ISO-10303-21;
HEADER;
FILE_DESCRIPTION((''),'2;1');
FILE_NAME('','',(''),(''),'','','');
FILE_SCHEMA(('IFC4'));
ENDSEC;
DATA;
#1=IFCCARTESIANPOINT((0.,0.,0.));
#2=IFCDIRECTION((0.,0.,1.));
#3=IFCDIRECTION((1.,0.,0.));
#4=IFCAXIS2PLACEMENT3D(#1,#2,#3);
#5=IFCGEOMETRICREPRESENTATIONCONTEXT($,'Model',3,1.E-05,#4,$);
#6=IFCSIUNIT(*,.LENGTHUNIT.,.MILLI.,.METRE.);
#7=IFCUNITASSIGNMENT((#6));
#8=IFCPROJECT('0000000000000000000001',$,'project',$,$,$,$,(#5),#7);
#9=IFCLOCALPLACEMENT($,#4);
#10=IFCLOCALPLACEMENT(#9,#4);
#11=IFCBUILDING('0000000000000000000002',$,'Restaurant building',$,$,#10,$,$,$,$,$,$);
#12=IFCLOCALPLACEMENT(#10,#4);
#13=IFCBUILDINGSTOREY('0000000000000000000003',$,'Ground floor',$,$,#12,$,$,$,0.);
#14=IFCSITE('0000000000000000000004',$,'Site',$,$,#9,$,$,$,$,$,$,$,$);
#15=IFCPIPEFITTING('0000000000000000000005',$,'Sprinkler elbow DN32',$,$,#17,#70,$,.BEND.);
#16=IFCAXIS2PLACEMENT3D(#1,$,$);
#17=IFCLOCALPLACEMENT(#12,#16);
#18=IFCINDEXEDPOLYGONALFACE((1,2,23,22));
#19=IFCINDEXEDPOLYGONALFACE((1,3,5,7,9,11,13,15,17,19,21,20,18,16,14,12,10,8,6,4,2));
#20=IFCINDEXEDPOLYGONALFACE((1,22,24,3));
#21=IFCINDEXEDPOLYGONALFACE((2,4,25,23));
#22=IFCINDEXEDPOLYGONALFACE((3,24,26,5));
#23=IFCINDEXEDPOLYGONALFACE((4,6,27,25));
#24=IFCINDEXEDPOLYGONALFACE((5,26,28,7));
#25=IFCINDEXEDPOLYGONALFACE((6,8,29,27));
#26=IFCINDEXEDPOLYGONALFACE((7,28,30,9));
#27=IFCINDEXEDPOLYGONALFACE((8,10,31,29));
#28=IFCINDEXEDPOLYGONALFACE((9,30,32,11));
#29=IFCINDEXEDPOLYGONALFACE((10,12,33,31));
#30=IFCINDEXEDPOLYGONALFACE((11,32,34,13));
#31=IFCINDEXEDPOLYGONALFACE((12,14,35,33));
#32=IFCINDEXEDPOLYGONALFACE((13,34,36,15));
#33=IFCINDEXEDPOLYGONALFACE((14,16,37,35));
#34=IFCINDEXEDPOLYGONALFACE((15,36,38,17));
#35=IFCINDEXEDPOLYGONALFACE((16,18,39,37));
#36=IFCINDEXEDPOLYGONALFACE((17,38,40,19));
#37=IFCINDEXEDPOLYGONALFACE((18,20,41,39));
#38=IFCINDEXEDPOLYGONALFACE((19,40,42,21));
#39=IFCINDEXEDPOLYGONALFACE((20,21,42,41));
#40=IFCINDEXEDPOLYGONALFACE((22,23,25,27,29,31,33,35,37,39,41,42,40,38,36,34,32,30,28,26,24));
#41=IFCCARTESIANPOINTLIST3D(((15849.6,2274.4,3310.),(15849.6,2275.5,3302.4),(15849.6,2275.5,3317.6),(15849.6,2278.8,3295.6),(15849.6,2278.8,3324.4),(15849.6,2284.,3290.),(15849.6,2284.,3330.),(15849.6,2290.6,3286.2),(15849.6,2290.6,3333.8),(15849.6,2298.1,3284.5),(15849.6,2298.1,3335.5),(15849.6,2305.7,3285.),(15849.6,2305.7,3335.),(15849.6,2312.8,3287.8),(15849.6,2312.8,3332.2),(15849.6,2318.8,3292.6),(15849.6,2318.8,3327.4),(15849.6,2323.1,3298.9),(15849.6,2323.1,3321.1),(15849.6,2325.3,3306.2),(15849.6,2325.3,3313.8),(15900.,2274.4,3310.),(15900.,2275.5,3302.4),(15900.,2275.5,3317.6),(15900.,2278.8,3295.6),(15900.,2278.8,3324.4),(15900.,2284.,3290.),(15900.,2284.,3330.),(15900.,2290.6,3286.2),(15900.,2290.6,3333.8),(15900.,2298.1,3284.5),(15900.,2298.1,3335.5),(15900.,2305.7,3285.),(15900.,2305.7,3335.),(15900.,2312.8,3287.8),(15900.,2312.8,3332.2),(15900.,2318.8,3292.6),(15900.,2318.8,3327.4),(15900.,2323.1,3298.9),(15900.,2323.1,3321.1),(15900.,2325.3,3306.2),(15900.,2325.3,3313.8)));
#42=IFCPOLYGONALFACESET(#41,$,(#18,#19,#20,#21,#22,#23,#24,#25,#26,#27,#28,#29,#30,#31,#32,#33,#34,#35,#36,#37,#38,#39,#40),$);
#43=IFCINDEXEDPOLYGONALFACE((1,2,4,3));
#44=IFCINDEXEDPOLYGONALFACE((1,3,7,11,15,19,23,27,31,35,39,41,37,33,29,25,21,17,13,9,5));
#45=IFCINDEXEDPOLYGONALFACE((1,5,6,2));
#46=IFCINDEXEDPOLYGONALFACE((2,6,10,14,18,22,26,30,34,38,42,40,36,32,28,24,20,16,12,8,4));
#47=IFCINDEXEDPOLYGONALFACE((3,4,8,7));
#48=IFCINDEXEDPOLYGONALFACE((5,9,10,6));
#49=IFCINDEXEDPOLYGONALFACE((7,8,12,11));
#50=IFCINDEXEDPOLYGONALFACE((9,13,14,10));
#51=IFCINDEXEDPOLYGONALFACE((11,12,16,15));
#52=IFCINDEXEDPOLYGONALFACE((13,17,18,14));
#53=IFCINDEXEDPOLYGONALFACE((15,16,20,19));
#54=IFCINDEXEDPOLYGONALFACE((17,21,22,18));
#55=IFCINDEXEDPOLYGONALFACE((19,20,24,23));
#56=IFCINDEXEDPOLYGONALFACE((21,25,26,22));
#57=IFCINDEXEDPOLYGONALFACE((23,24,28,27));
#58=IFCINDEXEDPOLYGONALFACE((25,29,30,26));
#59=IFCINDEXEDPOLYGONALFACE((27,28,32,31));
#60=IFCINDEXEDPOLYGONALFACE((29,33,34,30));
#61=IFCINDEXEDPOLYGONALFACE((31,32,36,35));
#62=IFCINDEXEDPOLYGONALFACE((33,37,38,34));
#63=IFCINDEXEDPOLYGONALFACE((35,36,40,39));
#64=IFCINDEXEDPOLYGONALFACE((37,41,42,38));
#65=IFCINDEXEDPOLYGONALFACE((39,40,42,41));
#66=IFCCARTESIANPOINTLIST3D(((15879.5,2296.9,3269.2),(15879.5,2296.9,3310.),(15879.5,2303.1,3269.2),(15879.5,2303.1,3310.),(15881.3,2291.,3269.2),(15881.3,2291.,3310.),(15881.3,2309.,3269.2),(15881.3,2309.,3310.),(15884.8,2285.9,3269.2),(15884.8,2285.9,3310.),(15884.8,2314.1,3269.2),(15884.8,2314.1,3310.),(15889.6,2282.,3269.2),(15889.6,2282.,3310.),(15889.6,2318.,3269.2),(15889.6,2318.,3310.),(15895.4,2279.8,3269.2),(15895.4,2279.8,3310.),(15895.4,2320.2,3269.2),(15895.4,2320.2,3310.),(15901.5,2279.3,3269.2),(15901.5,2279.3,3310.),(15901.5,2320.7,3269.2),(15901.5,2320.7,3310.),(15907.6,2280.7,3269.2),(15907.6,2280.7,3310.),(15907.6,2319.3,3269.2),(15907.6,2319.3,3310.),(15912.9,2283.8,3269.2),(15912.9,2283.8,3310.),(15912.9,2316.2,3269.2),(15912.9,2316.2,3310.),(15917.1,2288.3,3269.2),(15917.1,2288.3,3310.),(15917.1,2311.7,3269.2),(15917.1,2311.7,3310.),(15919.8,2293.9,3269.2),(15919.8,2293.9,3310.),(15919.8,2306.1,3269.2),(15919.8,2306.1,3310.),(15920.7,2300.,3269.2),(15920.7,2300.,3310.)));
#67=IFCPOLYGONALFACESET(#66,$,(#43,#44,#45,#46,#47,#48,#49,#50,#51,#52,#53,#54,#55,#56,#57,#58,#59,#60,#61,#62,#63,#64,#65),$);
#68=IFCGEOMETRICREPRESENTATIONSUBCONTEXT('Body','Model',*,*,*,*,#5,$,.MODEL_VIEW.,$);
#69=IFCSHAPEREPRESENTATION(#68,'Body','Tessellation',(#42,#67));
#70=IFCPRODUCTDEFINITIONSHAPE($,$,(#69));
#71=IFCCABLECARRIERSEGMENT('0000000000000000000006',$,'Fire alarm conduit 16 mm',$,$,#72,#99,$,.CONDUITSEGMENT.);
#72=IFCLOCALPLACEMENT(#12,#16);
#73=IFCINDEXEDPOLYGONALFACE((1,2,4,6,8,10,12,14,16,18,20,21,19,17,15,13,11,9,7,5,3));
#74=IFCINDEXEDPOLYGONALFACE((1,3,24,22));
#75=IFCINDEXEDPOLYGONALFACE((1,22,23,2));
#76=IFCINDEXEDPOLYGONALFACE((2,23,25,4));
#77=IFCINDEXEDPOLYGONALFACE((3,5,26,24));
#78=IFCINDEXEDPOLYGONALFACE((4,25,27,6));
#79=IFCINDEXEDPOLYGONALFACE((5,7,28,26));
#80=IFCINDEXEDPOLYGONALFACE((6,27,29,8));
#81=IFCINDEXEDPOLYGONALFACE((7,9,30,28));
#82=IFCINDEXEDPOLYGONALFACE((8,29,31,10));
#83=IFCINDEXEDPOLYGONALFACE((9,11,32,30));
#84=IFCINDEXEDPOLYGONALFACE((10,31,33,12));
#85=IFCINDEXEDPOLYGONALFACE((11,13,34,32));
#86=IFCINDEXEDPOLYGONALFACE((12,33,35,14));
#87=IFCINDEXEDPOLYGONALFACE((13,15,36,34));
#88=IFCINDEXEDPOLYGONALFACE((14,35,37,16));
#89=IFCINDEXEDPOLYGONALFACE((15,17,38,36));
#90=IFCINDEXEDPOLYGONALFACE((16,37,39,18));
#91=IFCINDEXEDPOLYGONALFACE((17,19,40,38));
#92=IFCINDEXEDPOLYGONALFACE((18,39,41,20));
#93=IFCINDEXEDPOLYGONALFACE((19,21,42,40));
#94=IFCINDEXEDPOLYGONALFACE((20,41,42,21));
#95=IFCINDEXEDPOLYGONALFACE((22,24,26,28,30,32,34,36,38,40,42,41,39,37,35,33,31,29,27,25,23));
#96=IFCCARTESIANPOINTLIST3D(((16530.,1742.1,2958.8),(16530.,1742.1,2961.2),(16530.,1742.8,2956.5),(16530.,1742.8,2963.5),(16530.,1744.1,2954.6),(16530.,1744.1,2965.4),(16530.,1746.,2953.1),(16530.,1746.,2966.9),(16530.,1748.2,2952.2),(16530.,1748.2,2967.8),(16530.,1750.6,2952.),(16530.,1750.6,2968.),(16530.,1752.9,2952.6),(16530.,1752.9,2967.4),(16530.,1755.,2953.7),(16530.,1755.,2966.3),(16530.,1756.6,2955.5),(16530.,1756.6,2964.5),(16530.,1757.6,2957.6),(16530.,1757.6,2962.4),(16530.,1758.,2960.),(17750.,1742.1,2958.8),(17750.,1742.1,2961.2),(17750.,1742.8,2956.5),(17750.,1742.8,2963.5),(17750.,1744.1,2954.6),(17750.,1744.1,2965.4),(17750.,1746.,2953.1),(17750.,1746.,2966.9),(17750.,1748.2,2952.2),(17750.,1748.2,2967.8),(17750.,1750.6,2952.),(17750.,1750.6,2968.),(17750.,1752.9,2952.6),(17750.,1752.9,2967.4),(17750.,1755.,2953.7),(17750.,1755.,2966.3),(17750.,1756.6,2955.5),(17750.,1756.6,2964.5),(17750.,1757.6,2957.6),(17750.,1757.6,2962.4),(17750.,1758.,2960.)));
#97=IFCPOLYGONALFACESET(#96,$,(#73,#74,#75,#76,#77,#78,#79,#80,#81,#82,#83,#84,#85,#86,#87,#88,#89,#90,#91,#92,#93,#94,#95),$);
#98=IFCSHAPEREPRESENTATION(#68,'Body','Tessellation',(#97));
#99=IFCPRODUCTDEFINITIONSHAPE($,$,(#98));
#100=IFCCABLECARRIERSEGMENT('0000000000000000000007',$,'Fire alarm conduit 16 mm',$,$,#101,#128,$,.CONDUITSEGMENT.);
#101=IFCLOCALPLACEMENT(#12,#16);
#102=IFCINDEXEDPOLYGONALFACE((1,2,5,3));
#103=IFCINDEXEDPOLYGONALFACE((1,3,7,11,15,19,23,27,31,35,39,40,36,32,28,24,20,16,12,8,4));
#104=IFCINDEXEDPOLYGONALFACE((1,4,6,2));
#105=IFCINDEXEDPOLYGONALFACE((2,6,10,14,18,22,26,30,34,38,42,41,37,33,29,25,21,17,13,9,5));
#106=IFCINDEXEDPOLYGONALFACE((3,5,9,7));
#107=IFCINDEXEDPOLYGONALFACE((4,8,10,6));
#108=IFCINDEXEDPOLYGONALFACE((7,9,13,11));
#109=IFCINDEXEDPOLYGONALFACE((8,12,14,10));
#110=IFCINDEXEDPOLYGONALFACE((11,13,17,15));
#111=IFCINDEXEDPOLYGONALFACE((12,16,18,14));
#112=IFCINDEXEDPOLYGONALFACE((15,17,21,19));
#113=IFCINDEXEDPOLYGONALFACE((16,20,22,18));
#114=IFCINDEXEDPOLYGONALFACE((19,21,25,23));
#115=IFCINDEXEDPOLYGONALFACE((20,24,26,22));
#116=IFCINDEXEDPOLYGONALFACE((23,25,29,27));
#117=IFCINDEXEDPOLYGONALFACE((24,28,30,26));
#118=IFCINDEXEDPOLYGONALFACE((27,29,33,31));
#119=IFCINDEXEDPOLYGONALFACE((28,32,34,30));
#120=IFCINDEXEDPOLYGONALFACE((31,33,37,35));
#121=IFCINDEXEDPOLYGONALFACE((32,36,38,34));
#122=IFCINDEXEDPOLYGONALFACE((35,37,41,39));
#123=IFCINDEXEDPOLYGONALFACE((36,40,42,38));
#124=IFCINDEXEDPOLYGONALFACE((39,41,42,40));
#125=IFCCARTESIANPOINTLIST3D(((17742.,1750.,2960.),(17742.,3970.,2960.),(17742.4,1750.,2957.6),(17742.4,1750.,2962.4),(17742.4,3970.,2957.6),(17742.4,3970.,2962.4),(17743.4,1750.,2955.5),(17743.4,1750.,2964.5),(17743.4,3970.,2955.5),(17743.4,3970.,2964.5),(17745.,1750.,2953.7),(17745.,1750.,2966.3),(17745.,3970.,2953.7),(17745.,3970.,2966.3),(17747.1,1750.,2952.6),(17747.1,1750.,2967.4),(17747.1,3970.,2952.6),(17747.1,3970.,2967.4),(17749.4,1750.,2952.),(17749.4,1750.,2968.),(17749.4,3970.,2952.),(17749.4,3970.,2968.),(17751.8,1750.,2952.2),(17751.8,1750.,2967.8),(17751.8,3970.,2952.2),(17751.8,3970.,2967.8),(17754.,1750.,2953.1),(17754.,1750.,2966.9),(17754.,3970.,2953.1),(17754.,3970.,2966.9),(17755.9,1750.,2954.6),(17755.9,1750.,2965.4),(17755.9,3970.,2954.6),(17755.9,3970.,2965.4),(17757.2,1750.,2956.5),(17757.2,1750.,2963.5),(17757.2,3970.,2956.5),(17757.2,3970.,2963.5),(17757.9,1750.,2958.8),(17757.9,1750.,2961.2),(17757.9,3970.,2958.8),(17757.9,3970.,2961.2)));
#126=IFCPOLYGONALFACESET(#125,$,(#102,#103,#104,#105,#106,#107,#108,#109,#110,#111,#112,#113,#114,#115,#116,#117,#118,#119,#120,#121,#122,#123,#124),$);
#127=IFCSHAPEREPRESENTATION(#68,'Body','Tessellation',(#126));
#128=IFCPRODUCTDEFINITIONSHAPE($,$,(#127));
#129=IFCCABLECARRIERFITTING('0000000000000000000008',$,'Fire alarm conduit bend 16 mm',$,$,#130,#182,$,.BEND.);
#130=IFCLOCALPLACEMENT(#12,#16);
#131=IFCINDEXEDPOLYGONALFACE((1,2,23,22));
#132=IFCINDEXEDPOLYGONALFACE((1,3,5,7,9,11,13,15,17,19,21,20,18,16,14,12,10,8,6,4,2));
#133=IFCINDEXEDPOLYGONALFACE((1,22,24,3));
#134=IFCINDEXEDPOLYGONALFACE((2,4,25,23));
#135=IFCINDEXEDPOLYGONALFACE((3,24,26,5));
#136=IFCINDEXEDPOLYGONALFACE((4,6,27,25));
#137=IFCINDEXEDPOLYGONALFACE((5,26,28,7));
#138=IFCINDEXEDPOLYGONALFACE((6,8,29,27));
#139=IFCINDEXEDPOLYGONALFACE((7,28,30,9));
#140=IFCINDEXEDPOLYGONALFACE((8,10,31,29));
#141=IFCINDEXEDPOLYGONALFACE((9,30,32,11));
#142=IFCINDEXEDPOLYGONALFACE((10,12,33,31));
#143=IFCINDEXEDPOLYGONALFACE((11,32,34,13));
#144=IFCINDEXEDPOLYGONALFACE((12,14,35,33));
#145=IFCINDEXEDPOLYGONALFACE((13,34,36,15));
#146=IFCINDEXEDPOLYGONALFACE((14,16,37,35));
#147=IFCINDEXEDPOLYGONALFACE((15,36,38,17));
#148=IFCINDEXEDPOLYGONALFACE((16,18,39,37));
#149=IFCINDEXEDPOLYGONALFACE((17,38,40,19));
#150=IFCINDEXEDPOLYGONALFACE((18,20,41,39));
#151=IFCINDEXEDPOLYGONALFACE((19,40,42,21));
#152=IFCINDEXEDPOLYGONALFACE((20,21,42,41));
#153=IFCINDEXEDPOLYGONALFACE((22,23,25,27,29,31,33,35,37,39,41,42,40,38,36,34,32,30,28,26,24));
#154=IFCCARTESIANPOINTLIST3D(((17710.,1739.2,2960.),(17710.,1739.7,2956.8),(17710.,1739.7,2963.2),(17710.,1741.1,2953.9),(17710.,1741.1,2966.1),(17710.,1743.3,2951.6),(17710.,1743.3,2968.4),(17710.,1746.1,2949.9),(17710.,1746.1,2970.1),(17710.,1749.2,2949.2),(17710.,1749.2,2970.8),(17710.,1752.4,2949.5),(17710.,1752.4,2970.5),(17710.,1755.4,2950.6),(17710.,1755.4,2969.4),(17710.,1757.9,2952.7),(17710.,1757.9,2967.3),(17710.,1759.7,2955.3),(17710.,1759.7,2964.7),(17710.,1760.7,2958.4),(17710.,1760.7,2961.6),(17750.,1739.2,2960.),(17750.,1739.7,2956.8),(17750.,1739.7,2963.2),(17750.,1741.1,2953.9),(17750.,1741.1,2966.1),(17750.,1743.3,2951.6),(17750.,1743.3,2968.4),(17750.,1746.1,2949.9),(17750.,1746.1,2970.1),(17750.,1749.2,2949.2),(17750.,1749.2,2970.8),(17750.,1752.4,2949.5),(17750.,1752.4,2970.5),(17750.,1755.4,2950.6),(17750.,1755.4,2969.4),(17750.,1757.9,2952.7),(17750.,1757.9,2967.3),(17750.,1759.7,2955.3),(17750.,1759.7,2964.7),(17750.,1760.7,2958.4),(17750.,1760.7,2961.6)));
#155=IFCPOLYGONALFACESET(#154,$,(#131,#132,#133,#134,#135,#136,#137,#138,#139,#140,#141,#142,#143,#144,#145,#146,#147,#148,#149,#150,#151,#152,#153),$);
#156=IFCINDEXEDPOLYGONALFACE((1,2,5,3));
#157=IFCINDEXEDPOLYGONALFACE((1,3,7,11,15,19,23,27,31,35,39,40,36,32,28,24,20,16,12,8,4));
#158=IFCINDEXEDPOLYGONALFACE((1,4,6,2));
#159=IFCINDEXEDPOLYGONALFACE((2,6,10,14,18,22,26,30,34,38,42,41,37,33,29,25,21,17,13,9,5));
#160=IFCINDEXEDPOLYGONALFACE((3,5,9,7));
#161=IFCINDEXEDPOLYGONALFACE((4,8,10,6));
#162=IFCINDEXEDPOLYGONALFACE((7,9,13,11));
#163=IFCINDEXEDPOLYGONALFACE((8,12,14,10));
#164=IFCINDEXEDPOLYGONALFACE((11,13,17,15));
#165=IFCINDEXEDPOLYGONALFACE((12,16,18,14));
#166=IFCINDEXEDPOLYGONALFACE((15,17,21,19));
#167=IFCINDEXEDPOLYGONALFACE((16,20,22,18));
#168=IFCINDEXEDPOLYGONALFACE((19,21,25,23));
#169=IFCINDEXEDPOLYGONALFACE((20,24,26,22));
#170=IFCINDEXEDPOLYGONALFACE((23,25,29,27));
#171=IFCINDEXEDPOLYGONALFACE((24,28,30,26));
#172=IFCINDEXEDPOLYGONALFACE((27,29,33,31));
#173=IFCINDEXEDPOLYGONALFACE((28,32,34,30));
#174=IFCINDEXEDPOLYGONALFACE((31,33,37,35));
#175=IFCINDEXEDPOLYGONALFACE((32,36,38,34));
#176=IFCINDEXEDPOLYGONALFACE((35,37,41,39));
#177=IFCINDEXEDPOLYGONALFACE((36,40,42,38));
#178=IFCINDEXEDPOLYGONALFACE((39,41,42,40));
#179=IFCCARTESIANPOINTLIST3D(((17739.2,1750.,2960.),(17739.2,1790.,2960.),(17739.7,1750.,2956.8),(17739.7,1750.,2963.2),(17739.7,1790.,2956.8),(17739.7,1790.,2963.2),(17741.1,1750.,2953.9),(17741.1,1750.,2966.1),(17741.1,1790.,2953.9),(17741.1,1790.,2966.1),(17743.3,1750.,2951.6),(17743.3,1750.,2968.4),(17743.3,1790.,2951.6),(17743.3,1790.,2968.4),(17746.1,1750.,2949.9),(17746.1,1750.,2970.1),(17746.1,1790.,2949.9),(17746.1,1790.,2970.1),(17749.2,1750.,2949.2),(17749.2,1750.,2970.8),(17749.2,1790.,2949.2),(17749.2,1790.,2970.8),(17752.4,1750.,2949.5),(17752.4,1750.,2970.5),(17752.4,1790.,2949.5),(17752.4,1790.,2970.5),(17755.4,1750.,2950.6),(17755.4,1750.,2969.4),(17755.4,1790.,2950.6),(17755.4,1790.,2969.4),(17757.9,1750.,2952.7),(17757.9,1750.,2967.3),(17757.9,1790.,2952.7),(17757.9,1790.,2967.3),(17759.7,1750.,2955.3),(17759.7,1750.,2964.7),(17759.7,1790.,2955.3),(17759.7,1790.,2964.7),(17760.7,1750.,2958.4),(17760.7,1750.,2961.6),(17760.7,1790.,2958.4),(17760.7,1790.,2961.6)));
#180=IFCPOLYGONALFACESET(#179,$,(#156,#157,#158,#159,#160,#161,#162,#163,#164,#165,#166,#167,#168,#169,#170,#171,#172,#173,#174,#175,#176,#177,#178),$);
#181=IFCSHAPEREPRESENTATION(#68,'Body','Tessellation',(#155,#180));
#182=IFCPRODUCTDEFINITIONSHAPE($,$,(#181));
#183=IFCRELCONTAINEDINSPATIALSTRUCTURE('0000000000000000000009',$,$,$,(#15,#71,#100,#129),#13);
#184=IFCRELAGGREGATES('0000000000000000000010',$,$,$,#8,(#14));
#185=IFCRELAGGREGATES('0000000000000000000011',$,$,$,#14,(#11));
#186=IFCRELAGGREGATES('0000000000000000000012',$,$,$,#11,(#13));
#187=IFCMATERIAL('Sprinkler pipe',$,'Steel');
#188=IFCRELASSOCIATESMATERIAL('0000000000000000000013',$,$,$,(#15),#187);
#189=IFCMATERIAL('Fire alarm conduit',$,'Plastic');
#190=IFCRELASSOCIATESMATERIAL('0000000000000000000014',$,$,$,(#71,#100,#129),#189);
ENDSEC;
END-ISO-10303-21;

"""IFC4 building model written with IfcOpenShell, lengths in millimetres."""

from ifc_helpers import new_model, si_unit, frame, origin_with_axes, origin_2d, place, context, subcontext, project, spatial, circle, extrude, material, element, save


model = new_model("IFC4")

# Units and contexts
model_context = context("Model", 3, precision=1e-05, world=origin_with_axes())
body_context = subcontext(model_context, "Body", "Model", "MODEL_VIEW")
ifc_project = project(units=[si_unit("LENGTHUNIT", "METRE", prefix="MILLI")], contexts=[model_context])

# Site, building, storey
site_placement = place(None, origin_with_axes())
site = spatial("IfcSite", under=ifc_project, at=site_placement, Name="Site")
building_placement = place(site_placement, origin_with_axes())
building = spatial("IfcBuilding", under=site, at=building_placement, Name="Restaurant building")
storey_placement = place(building_placement, origin_with_axes())
storey = spatial("IfcBuildingStorey", under=building, at=storey_placement, Name="Ground floor", Elevation=0.0)

# Shared definitions
ifc_material_1 = material(Name="Sprinkler pipe", Category="Steel")

# Pipe fitting
pipe_fitting_placement = place(storey_placement, frame((15900.0, 2300.0, 3310.0)))
element("IfcPipeFitting", 1, at=pipe_fitting_placement, inside=storey, material=ifc_material_1, Name="Sprinkler elbow DN32", PredefinedType="BEND", context=body_context, shape_type="SweptSolid", body=[
    extrude(circle(Radius=25.6, at=origin_2d()), frame((0.0, 0.0, 0.0), z_axis=(-1.0, 0.0, 0.0), x_axis=(0.0, -1.0, 0.0)), (0.0, 0.0, 1.0), 50.4),
    extrude(circle(Radius=20.7, at=origin_2d()), frame((0.0, 0.0, 0.0), z_axis=(0.0, 0.0, -1.0), x_axis=(1.0, 0.0, 0.0)), (0.0, 0.0, 1.0), 40.8),
])

# Cable carrier segments
ifc_material_2 = material(Name="Fire alarm conduit", Category="Plastic")
cable_carrier_segment_1_placement = place(storey_placement, frame((16530.0, 1750.0, 2960.0)))
element("IfcCableCarrierSegment", 2, at=cable_carrier_segment_1_placement, inside=storey, material=ifc_material_2, Name="Fire alarm conduit 16 mm", PredefinedType="CONDUITSEGMENT", context=body_context, shape_type="SweptSolid", body=[
    extrude(circle(Radius=8.0, at=origin_2d()), frame((0.0, 0.0, 0.0), z_axis=(1.0, 0.0, 0.0), x_axis=(0.0, 1.0, 0.0)), (0.0, 0.0, 1.0), 1220.0),
])
cable_carrier_segment_2_placement = place(storey_placement, frame((17750.0, 1750.0, 2960.0)))
element("IfcCableCarrierSegment", 3, at=cable_carrier_segment_2_placement, inside=storey, material=ifc_material_2, Name="Fire alarm conduit 16 mm", PredefinedType="CONDUITSEGMENT", context=body_context, shape_type="SweptSolid", body=[
    extrude(circle(Radius=8.0, at=origin_2d()), frame((0.0, 0.0, 0.0), z_axis=(0.0, 1.0, 0.0), x_axis=(-1.0, 0.0, 0.0)), (0.0, 0.0, 1.0), 2220.0),
])

# Cable carrier fitting
cable_carrier_fitting_1_placement = place(storey_placement, frame((17750.0, 1750.0, 2960.0)))
element("IfcCableCarrierFitting", 4, at=cable_carrier_fitting_1_placement, inside=storey, material=ifc_material_2, Name="Fire alarm conduit bend 16 mm", PredefinedType="BEND", context=body_context, shape_type="SweptSolid", body=[
    extrude(circle(Radius=10.8, at=origin_2d()), frame((0.0, 0.0, 0.0), z_axis=(-1.0, 0.0, 0.0), x_axis=(0.0, -1.0, 0.0)), (0.0, 0.0, 1.0), 40.0),
    extrude(circle(Radius=10.8, at=origin_2d()), frame((0.0, 0.0, 0.0), z_axis=(0.0, 1.0, 0.0), x_axis=(-1.0, 0.0, 0.0)), (0.0, 0.0, 1.0), 40.0),
])

save(model, "model.ifc")
